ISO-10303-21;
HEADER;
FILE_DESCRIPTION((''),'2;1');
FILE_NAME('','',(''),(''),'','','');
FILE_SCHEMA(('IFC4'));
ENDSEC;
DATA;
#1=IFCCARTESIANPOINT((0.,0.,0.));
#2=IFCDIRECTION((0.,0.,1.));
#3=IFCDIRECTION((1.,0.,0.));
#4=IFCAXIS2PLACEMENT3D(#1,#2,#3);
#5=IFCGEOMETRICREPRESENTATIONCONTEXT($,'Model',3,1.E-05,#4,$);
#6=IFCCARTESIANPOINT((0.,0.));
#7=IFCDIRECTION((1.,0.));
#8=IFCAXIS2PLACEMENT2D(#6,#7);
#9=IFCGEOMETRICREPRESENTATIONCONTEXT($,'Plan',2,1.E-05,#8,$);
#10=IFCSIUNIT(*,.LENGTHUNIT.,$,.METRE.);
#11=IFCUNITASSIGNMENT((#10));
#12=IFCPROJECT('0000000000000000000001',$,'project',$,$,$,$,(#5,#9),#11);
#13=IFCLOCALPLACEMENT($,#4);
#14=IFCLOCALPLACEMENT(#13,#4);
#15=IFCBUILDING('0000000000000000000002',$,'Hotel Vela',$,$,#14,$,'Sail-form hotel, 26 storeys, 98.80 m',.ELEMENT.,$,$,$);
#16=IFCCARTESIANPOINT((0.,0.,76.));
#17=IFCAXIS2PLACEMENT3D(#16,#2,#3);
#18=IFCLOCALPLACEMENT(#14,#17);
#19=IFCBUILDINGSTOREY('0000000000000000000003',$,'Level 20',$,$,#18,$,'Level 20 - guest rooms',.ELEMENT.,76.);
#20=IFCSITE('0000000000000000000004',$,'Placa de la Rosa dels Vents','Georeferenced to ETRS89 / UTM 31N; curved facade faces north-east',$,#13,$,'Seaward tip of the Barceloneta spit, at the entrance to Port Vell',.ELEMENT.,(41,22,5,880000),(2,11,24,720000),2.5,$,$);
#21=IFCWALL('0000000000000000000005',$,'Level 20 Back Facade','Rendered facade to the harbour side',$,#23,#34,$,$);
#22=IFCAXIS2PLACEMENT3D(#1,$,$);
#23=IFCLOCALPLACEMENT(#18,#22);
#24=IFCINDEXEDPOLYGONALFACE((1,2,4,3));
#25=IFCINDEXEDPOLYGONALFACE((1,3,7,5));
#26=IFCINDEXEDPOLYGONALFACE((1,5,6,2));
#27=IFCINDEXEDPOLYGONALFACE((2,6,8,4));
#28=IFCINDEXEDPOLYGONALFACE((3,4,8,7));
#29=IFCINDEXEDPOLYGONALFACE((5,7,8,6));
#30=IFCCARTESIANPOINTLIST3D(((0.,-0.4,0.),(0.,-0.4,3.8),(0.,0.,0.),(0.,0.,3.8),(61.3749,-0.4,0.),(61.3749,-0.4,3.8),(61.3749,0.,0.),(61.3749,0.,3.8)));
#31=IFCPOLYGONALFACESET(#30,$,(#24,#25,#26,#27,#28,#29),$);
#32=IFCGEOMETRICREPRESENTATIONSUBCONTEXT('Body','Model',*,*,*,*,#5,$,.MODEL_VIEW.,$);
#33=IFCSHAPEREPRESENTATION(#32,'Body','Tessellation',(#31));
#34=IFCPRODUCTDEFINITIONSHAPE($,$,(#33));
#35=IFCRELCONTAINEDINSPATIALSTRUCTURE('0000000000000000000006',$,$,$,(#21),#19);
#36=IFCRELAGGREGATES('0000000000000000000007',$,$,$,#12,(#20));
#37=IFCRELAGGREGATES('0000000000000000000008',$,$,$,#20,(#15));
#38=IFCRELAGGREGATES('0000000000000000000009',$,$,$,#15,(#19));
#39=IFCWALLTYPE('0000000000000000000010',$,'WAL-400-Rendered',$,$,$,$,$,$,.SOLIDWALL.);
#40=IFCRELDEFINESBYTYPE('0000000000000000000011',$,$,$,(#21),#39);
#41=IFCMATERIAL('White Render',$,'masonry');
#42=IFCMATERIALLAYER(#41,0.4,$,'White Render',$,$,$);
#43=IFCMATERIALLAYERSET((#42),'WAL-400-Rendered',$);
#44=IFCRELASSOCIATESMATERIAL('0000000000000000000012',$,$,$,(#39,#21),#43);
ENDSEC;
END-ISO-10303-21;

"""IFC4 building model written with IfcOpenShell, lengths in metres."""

from ifc_helpers import new_model, si_unit, frame, origin_with_axes, origin_2d_with_axis, place, context, subcontext, project, spatial, line, indexed_curve, outline, extrude, material, layer, layer_set, layer_usage, type_object, element, save


model = new_model("IFC4")

# Units and contexts
model_context = context("Model", 3, precision=1e-05, world=origin_with_axes())
plan_context = context("Plan", 2, precision=1e-05, world=origin_2d_with_axis())
body_context = subcontext(model_context, "Body", "Model", "MODEL_VIEW")
ifc_project = project(units=[si_unit("LENGTHUNIT", "METRE")], contexts=[model_context, plan_context])

# Site, building, storey
site_placement = place(None, origin_with_axes())
site = spatial("IfcSite", under=ifc_project, at=site_placement, Name="Placa de la Rosa dels Vents", Description="Georeferenced to ETRS89 / UTM 31N; curved facade faces north-east", LongName="Seaward tip of the Barceloneta spit, at the entrance to Port Vell", CompositionType="ELEMENT", RefLatitude=(41, 22, 5, 880000), RefLongitude=(2, 11, 24, 720000), RefElevation=2.5)
building_placement = place(site_placement, origin_with_axes())
building = spatial("IfcBuilding", under=site, at=building_placement, Name="Hotel Vela", LongName="Sail-form hotel, 26 storeys, 98.80 m", CompositionType="ELEMENT")
storey_placement = place(building_placement, frame((0.0, 0.0, 76.0), z_axis=(0.0, 0.0, 1.0), x_axis=(1.0, 0.0, 0.0)))
storey = spatial("IfcBuildingStorey", under=building, at=storey_placement, Name="Level 20", LongName="Level 20 - guest rooms", CompositionType="ELEMENT", Elevation=76.0)

# Wall
ifc_material_1 = material(Name="White Render", Category="masonry")
ifc_layer_1 = layer(ifc_material_1, 0.4, Name="White Render")
ifc_layer_set_1 = layer_set([ifc_layer_1], Name="WAL-400-Rendered")
ifc_layer_usage_1 = layer_usage(ifc_layer_set_1, "AXIS2", "POSITIVE", 0.0)
wall_type = type_object("IfcWallType", Name="WAL-400-Rendered", PredefinedType="SOLIDWALL", material=ifc_layer_set_1)
wall_placement = place(storey_placement, frame((0.0, -0.4, 0.0), z_axis=(0.0, 0.0, 1.0), x_axis=(1.0, 0.0, 0.0)))
element("IfcWall", 1, at=wall_placement, inside=storey, type_object=wall_type, material=ifc_layer_usage_1, Name="Level 20 Back Facade", Description="Rendered facade to the harbour side", context=body_context, shape_type="SweptSolid", body=[
    extrude(outline(indexed_curve([(0.0, 0.0), (61.3749, 0.0), (61.3749, 0.4), (0.0, 0.4)], segments=[line(1, 2, 3, 4, 1)])), origin_with_axes(), (0.0, 0.0, 1.0), 3.8),
])

save(model, "model.ifc")
